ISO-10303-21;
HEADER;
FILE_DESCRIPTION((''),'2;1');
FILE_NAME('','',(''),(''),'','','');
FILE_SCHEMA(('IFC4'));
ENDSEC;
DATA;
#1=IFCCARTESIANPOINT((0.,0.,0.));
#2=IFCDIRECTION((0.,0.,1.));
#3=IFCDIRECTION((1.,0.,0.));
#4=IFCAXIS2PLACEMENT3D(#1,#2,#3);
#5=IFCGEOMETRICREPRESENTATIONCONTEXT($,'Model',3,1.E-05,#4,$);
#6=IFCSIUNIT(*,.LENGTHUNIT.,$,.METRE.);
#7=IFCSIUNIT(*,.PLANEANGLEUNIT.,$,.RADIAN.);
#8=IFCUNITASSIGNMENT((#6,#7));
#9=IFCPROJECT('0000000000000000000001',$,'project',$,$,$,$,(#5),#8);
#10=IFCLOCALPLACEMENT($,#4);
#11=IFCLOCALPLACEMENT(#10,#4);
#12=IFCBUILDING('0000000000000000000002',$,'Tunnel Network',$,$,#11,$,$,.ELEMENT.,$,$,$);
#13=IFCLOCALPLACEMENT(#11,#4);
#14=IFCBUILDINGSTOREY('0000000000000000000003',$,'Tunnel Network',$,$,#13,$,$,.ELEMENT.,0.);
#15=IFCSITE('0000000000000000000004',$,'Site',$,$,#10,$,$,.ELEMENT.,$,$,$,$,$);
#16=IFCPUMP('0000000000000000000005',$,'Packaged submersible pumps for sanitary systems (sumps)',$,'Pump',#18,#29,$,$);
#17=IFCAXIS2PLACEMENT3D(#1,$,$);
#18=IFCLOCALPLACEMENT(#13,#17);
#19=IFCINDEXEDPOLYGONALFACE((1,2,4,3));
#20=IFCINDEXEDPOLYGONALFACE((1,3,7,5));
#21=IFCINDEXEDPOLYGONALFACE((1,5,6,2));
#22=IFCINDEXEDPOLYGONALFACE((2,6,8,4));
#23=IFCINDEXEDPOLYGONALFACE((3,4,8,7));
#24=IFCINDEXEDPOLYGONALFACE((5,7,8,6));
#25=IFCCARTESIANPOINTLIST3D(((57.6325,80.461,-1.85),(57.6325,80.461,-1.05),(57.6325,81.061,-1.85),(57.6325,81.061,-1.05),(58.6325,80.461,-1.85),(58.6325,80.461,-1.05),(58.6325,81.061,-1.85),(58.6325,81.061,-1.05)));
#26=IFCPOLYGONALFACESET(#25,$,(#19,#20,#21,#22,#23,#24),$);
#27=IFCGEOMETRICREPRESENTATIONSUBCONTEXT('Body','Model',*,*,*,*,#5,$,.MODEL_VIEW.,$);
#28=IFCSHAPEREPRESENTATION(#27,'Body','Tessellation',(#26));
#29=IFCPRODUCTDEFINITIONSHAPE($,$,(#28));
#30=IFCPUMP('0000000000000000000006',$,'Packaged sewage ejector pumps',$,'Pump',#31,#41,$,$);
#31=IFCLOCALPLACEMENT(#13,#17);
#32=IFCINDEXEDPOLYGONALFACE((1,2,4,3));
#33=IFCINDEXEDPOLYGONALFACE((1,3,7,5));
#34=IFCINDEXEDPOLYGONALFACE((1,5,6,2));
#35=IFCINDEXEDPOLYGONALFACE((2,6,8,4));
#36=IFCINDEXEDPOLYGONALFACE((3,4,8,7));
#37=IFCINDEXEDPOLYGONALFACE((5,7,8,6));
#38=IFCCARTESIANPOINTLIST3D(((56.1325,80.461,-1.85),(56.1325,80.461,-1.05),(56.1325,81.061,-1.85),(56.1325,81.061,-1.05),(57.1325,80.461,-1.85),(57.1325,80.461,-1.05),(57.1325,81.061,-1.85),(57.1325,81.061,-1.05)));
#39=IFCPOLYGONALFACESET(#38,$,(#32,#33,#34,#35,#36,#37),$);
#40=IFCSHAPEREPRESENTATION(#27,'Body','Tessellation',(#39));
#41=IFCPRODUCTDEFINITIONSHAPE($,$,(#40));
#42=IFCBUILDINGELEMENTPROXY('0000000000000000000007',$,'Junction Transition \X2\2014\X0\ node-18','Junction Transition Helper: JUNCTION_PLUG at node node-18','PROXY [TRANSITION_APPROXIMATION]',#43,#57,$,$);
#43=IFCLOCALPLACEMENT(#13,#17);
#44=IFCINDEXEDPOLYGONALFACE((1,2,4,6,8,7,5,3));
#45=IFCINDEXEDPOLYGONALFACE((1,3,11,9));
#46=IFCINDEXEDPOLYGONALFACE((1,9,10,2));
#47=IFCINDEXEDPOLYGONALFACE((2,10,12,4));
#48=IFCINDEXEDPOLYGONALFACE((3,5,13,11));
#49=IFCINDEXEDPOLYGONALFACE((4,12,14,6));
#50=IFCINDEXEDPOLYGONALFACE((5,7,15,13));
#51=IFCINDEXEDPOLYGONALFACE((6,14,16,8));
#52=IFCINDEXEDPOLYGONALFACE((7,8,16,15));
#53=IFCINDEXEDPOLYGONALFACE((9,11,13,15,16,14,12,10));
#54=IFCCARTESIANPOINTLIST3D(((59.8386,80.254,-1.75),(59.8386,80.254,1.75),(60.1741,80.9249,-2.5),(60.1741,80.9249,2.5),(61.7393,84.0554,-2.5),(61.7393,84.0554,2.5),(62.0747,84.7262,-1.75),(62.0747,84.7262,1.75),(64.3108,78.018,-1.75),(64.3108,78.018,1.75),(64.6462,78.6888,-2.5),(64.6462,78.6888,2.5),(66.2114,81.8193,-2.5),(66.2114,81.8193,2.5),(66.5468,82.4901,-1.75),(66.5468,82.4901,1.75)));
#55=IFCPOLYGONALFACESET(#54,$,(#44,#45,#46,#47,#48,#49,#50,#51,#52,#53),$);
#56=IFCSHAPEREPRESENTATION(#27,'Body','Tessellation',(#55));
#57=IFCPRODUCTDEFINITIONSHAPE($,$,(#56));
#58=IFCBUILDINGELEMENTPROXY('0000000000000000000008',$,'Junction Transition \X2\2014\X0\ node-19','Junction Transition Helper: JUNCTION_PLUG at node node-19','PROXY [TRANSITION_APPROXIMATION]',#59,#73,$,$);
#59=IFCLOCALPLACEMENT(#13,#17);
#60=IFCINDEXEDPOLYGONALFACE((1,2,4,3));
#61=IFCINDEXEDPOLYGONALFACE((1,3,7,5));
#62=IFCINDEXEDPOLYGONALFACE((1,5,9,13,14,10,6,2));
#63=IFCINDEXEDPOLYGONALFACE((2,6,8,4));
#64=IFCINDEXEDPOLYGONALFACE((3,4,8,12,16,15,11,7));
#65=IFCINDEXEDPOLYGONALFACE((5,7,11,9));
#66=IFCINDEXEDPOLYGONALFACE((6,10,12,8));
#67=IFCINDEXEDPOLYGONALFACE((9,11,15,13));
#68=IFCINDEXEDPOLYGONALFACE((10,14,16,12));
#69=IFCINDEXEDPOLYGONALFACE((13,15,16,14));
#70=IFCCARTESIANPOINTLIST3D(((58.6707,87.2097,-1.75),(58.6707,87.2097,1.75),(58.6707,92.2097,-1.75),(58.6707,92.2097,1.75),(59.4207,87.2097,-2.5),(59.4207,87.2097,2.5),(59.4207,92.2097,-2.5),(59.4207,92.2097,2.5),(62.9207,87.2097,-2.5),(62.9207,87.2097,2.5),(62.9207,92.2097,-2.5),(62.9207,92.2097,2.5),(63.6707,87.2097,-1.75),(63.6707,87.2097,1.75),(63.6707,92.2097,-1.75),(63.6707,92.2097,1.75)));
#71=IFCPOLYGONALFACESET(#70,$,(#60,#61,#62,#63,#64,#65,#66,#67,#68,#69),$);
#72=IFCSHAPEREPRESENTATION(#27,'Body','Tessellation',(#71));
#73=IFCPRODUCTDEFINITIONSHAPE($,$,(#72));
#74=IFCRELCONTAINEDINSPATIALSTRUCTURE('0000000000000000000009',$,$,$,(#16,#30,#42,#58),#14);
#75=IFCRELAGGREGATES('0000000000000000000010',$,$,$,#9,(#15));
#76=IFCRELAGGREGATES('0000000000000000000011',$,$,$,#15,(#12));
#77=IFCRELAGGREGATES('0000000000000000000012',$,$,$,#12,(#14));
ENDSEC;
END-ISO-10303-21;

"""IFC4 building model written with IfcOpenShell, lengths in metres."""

from ifc_helpers import new_model, si_unit, frame, origin_with_axes, origin_2d_with_axis, place, context, subcontext, project, spatial, polyline, rectangle, outline, extrude, element, save


model = new_model("IFC4")

# Units and contexts
model_context = context("Model", 3, precision=1e-05, world=origin_with_axes())
body_context = subcontext(model_context, "Body", "Model", "MODEL_VIEW")
ifc_project = project(units=[si_unit("LENGTHUNIT", "METRE"), si_unit("PLANEANGLEUNIT", "RADIAN")], contexts=[model_context])

# Site, building, storey
site_placement = place(None, origin_with_axes())
site = spatial("IfcSite", under=ifc_project, at=site_placement, Name="Site", CompositionType="ELEMENT")
building_placement = place(site_placement, origin_with_axes())
building = spatial("IfcBuilding", under=site, at=building_placement, Name="Tunnel Network", CompositionType="ELEMENT")
storey_placement = place(building_placement, origin_with_axes())
storey = spatial("IfcBuildingStorey", under=building, at=storey_placement, Name="Tunnel Network", CompositionType="ELEMENT", Elevation=0.0)

# Pumps
for number, where, z_axis, x_axis, name in (
    (1, (58.1325, 80.761, -1.85), (0.0, 0.0, 1.0), (1.0, 0.0, 0.0), "Packaged submersible pumps for sanitary systems (sumps)"),
    (2, (56.6325, 80.761, -1.85), (0.0, 0.0, 1.0), (1.0, 0.0, 0.0), "Packaged sewage ejector pumps"),
):
    element("IfcPump", number, at=place(storey_placement, frame(where, z_axis=z_axis, x_axis=x_axis)), inside=storey, Name=name, ObjectType="Pump", context=body_context, shape_type="SweptSolid", body=[
        extrude(rectangle(XDim=1.0, YDim=0.6, at=origin_2d_with_axis()), origin_with_axes(), (0.0, 0.0, 1.0), 0.8),
    ])

# Building element proxies
for number, where, z_axis, x_axis, name, description in (
    (3, (65.4288, 80.254, 0.0), (-0.894427, 0.447214, 0.0), (0.447214, 0.894427, 0.0), "Junction Transition — node-18", "Junction Transition Helper: JUNCTION_PLUG at node node-18"),
    (4, (61.1707, 87.2097, 0.0), (0.0, 1.0, 0.0), (1.0, 0.0, 0.0), "Junction Transition — node-19", "Junction Transition Helper: JUNCTION_PLUG at node node-19"),
):
    element("IfcBuildingElementProxy", number, at=place(storey_placement, frame(where, z_axis=z_axis, x_axis=x_axis)), inside=storey, Name=name, Description=description, ObjectType="PROXY [TRANSITION_APPROXIMATION]", context=body_context, shape_type="SweptSolid", body=[
        extrude(outline(polyline([(1.75, 2.5), (2.5, 1.75), (2.5, -1.75), (1.75, -2.5), (-1.75, -2.5), (-2.5, -1.75), (-2.5, 1.75), (-1.75, 2.5), (1.75, 2.5)])), origin_with_axes(), (0.0, 0.0, 1.0), 5.0),
    ])

save(model, "model.ifc")
